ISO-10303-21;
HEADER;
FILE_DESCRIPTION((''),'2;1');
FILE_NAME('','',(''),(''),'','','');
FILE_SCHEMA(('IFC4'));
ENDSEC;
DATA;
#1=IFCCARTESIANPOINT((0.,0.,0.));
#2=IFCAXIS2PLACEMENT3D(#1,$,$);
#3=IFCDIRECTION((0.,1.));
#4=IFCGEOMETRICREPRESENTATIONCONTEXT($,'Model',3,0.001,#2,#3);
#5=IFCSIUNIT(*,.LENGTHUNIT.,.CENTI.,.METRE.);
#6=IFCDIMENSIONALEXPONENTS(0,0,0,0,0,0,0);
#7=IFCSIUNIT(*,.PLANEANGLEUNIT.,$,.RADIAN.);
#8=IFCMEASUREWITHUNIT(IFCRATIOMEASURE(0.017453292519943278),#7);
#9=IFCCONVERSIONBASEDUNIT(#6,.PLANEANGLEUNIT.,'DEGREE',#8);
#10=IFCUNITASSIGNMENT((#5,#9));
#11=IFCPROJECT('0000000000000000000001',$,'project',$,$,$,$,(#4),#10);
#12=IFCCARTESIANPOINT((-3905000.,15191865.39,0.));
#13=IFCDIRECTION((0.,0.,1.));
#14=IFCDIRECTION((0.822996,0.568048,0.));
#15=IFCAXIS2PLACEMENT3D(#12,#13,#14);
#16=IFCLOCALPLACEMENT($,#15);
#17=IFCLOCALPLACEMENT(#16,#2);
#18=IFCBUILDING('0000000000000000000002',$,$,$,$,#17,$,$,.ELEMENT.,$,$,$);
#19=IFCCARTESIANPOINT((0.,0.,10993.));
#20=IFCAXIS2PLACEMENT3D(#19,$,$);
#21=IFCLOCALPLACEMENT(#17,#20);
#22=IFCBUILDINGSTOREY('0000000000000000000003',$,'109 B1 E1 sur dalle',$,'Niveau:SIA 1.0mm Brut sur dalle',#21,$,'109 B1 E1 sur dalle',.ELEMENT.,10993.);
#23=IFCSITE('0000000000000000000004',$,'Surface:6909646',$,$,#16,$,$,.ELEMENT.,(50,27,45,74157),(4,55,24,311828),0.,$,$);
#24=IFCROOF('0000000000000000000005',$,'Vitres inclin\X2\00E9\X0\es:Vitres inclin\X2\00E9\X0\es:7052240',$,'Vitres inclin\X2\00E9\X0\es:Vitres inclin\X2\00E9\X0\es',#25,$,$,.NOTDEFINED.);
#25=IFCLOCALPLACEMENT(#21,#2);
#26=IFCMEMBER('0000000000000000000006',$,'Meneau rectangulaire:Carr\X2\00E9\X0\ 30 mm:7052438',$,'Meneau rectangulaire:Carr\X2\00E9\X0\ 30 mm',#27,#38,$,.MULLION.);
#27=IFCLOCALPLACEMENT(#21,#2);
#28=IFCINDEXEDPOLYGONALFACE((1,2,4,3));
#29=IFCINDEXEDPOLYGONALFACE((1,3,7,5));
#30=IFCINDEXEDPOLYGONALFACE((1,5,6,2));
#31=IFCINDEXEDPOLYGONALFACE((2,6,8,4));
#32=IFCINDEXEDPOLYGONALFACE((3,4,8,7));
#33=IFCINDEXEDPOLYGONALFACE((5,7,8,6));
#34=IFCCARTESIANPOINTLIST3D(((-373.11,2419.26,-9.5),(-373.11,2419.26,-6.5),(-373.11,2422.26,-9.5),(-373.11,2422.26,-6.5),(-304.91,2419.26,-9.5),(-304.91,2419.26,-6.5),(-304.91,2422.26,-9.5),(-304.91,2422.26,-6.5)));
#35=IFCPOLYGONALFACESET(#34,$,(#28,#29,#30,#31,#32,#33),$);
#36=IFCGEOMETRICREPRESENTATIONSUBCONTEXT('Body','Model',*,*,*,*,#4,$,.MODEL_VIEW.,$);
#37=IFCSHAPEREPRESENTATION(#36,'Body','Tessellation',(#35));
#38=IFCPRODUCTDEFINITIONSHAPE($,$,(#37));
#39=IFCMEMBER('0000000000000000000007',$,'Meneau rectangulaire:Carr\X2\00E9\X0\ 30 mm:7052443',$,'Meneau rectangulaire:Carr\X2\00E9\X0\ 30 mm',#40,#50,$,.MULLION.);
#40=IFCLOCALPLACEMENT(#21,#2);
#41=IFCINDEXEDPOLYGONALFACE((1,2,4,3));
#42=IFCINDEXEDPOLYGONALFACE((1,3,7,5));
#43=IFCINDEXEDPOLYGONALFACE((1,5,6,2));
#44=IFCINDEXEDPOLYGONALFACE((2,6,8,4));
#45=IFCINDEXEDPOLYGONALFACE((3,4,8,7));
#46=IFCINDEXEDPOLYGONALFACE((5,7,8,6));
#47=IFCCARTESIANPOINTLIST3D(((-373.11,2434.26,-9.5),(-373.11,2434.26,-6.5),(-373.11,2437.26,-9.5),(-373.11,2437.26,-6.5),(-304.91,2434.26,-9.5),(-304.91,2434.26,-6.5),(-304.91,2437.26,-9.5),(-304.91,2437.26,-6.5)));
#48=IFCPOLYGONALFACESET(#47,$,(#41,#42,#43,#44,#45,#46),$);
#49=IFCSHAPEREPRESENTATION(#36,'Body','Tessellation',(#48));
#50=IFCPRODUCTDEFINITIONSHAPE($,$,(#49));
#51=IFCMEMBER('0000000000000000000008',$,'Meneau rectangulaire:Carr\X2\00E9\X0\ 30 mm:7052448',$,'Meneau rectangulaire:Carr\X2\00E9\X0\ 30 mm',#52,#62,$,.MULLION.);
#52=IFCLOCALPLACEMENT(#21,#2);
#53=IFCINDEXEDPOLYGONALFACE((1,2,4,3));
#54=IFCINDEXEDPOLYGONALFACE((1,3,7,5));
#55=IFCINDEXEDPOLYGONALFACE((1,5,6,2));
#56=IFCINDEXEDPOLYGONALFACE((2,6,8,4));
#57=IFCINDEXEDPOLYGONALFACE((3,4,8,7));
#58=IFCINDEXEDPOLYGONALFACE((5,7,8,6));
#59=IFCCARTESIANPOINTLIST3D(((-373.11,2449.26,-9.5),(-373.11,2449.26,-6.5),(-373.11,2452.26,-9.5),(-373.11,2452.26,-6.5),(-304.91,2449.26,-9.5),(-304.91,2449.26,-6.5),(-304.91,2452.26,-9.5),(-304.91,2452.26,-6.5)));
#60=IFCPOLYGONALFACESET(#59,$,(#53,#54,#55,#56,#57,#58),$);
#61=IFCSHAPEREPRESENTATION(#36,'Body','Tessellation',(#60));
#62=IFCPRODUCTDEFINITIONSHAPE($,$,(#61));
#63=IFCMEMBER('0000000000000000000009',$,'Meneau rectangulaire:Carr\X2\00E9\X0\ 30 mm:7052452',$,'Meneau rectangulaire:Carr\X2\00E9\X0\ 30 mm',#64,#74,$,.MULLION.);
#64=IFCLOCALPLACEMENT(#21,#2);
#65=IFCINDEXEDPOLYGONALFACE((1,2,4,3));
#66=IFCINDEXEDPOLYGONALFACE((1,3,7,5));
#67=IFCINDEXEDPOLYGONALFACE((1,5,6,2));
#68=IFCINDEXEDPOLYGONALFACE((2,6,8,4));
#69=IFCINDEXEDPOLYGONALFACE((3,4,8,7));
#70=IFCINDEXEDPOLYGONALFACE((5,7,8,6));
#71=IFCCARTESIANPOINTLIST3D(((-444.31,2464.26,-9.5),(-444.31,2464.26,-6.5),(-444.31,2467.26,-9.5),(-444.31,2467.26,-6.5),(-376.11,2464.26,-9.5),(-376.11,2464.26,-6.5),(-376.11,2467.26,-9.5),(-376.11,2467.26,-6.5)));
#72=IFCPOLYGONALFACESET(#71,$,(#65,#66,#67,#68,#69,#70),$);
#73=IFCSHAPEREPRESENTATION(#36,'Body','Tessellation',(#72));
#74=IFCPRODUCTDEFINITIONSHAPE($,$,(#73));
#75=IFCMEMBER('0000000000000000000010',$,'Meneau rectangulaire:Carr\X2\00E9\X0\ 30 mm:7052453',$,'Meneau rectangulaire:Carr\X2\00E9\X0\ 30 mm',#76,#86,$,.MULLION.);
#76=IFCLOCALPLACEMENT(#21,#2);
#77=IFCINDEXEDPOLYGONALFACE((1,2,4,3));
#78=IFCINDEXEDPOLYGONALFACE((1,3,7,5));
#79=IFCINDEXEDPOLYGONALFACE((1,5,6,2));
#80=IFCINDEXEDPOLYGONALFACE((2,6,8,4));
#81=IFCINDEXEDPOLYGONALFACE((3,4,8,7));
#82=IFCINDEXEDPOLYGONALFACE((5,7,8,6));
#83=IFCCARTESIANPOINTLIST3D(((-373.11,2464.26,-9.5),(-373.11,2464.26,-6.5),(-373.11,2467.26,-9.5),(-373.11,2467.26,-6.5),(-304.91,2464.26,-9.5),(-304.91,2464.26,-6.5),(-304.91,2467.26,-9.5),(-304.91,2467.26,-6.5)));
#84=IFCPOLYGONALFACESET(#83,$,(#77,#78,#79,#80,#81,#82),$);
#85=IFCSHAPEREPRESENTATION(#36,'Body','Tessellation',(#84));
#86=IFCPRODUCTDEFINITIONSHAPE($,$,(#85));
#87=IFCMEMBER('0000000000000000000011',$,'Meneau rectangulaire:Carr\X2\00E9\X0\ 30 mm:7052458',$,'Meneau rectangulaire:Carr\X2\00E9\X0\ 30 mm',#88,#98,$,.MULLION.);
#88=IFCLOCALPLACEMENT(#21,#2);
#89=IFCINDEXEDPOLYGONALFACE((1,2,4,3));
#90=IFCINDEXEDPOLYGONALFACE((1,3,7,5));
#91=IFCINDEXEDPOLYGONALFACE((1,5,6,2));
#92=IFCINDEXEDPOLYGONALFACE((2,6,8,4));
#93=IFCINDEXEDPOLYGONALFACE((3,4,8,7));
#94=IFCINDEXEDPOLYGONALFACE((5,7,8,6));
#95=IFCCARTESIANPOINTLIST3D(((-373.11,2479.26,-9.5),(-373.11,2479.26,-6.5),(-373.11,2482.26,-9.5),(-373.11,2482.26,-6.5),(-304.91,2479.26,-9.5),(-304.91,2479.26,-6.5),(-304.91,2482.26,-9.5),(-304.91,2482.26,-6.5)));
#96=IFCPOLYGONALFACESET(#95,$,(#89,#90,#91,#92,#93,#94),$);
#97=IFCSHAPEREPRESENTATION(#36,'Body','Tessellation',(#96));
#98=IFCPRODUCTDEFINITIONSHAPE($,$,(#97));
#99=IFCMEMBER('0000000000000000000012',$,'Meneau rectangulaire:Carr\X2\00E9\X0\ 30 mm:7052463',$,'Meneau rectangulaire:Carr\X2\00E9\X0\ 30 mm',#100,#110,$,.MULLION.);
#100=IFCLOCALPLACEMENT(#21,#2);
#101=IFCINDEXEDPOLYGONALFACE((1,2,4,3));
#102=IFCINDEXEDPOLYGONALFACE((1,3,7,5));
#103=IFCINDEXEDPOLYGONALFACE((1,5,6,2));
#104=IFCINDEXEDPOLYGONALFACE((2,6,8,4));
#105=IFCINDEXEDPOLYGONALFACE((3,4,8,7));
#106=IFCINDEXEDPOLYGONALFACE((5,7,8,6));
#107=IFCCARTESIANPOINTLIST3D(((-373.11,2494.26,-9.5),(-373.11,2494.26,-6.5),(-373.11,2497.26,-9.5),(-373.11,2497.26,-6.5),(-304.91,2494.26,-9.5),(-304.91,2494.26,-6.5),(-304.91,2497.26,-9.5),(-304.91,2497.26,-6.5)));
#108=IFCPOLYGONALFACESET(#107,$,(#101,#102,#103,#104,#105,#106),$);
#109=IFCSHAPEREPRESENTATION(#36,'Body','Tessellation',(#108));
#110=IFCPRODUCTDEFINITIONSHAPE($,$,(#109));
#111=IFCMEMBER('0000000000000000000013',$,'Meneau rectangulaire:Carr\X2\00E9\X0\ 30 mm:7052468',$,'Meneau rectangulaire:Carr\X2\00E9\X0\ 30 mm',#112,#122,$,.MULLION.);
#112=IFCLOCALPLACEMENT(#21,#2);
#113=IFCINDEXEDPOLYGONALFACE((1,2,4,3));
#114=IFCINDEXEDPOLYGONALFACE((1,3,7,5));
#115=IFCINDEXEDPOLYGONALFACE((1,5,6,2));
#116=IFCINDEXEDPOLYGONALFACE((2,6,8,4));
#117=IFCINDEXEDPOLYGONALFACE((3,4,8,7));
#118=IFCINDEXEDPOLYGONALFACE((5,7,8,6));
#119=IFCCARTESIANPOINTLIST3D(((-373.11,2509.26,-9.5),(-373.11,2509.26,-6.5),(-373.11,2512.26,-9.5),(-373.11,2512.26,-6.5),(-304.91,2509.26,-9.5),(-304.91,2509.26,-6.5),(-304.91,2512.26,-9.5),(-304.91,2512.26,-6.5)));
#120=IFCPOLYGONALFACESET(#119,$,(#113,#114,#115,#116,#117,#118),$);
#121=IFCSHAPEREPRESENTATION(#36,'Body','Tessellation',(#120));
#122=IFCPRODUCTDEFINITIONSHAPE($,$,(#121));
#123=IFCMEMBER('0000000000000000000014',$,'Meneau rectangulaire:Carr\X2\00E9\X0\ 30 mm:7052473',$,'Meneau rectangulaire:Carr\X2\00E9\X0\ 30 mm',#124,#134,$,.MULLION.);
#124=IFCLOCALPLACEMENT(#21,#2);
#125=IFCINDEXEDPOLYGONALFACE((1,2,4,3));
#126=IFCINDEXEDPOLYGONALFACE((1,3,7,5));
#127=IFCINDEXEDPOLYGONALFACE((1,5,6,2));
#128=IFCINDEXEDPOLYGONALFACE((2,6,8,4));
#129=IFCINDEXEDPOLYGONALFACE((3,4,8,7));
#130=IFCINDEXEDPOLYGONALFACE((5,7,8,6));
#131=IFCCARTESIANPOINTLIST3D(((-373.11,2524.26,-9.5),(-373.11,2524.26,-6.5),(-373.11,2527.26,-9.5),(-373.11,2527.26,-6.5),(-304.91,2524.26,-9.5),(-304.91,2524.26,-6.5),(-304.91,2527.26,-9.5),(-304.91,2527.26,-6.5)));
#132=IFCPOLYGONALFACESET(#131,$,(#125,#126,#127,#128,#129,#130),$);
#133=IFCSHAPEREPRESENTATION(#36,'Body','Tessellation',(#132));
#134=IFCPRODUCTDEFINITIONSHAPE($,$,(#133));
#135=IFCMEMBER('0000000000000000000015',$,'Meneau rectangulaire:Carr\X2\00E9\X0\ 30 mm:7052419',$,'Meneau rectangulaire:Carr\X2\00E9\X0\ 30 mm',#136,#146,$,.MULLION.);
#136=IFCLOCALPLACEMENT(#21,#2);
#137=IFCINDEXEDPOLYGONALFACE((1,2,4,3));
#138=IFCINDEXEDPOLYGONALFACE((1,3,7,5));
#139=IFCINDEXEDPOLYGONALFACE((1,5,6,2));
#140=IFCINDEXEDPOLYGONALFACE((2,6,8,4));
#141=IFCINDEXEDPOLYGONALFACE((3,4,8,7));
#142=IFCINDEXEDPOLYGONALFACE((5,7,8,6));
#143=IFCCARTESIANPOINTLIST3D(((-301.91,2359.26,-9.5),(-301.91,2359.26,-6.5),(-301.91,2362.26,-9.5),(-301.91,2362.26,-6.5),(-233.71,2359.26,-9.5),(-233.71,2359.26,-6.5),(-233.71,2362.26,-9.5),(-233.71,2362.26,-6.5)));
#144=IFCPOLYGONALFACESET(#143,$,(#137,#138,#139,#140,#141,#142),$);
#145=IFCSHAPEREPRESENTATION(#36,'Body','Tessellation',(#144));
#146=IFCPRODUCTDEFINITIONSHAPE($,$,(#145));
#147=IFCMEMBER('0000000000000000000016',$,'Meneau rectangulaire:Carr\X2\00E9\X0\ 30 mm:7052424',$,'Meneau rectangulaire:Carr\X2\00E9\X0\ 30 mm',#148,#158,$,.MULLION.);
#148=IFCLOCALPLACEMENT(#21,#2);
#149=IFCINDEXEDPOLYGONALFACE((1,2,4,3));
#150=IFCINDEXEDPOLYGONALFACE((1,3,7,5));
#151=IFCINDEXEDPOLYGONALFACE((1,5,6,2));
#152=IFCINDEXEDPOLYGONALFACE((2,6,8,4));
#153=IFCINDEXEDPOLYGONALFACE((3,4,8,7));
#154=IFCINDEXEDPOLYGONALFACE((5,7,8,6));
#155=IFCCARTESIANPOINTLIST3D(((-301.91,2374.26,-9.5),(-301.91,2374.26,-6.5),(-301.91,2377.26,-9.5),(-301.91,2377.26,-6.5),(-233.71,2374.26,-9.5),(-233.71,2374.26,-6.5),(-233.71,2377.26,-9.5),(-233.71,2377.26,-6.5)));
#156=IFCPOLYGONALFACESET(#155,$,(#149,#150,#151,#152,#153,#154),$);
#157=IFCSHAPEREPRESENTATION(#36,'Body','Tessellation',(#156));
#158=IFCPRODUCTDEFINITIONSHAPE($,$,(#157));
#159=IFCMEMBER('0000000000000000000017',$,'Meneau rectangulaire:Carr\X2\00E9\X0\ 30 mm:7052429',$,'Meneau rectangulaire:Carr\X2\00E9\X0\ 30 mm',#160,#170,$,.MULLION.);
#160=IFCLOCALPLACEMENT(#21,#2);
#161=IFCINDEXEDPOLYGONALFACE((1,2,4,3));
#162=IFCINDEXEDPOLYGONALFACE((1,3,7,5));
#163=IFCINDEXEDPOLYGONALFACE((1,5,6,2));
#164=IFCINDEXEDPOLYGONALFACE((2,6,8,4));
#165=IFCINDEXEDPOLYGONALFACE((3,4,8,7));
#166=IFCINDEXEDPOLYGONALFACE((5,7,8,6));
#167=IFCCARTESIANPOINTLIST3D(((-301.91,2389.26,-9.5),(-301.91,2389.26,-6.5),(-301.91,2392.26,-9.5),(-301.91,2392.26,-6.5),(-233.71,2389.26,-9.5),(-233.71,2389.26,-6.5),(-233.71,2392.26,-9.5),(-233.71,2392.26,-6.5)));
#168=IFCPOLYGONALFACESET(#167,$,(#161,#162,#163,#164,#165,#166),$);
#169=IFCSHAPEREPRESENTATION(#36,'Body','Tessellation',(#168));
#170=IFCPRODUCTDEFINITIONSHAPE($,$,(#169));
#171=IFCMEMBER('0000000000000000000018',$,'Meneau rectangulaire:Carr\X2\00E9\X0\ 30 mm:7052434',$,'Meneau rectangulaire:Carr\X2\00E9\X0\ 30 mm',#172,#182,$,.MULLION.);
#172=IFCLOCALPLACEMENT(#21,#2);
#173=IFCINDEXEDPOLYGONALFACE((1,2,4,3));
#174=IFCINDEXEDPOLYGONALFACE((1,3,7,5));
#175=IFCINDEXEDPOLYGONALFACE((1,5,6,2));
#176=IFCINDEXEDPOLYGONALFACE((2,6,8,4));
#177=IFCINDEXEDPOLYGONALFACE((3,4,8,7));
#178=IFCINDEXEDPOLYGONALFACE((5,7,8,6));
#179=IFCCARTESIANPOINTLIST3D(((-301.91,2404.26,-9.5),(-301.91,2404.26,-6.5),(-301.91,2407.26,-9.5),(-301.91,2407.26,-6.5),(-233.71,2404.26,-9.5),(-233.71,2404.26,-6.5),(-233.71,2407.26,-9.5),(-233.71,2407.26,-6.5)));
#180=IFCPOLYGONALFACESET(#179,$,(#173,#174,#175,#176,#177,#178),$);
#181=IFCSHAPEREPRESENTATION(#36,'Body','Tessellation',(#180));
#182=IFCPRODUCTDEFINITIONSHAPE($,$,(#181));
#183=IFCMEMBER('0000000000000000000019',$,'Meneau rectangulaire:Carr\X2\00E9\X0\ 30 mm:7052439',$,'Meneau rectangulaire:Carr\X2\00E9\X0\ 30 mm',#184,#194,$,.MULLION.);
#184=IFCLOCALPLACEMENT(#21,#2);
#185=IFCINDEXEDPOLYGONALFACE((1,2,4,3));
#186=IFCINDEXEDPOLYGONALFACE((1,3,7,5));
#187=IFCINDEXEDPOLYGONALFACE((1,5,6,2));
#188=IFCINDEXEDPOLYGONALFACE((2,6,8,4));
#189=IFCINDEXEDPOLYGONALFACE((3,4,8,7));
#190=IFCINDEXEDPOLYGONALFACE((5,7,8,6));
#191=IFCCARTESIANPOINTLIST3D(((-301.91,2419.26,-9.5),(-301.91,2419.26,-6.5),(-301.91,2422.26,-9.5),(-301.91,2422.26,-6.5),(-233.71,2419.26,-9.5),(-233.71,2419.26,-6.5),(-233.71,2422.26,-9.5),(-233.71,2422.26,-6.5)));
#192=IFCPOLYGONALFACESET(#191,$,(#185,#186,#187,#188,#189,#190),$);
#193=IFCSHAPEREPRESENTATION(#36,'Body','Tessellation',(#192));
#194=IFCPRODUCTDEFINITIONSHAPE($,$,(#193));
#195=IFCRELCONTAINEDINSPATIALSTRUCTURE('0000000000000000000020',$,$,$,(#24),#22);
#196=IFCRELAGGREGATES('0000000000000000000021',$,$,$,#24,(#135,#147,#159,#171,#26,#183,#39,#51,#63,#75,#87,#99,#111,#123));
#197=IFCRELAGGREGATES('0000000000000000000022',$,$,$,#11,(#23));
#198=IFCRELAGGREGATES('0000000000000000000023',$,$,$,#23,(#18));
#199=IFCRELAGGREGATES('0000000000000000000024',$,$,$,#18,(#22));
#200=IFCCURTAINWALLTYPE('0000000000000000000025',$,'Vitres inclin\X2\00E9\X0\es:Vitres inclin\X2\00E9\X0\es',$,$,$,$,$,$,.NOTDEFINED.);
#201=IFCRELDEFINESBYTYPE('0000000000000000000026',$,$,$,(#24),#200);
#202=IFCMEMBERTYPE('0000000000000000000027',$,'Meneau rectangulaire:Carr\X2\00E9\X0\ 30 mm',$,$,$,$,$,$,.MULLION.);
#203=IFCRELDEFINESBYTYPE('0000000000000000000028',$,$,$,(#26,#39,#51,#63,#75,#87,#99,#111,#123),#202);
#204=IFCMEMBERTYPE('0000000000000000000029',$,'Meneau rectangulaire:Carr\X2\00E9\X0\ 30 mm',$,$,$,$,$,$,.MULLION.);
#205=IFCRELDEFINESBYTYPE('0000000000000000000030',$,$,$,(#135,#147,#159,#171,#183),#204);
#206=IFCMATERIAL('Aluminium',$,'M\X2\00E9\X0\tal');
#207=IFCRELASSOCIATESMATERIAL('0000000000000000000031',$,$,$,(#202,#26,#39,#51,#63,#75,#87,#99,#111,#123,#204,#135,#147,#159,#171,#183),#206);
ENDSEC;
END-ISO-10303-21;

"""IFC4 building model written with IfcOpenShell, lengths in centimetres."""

from ifc_helpers import new_model, entity, si_unit, converted_unit, direction, frame, origin, place, context, subcontext, project, spatial, indexed_curve, outline, extrude, source, transform, mapped, material, type_object, type_shapes, element, aggregate, save


model = new_model("IFC4")

# Units and contexts
model_context = context("Model", 3, precision=0.001, world=origin(), true_north=direction((0.0, 1.0)))
body_context = subcontext(model_context, "Body", "Model", "MODEL_VIEW")
ifc_project = project(units=[si_unit("LENGTHUNIT", "METRE", prefix="CENTI"), converted_unit("PLANEANGLEUNIT", "DEGREE", entity("IfcRatioMeasure", 0.017453292519943278), si_unit("PLANEANGLEUNIT", "RADIAN"), dimensions=[0, 0, 0, 0, 0, 0, 0])], contexts=[model_context])

# Site, building, storey
site_placement = place(None, frame((-3905000.0, 15191865.39, 0.0), z_axis=(0.0, 0.0, 1.0), x_axis=(0.822996, 0.568048, 0.0)))
site = spatial("IfcSite", under=ifc_project, at=site_placement, Name="Surface:6909646", CompositionType="ELEMENT", RefLatitude=(50, 27, 45, 74157), RefLongitude=(4, 55, 24, 311828), RefElevation=0.0)
building_placement = place(site_placement, origin())
building = spatial("IfcBuilding", under=site, at=building_placement, CompositionType="ELEMENT")
storey_placement = place(building_placement, frame((0.0, 0.0, 10993.0)))
storey = spatial("IfcBuildingStorey", under=building, at=storey_placement, Name="109 B1 E1 sur dalle", ObjectType="Niveau:SIA 1.0mm Brut sur dalle", LongName="109 B1 E1 sur dalle", CompositionType="ELEMENT", Elevation=10993.0)

# Roof, members
curtain_wall_type = type_object("IfcCurtainWallType", Name="Vitres inclinées:Vitres inclinées", PredefinedType="NOTDEFINED")
roof_placement = place(storey_placement, frame((0.0, 0.0, -10993.0)))
roof = element("IfcRoof", 1, at=roof_placement, inside=storey, type_object=curtain_wall_type, Name="Vitres inclinées:Vitres inclinées:7052240", ObjectType="Vitres inclinées:Vitres inclinées", PredefinedType="NOTDEFINED")
ifc_material = material(Name="Aluminium", Category="Métal")
member_type_1 = type_object("IfcMemberType", Name="Meneau rectangulaire:Carré 30 mm", PredefinedType="MULLION", material=ifc_material)
shared_shape_1 = source(origin(), body_context, "Body", "SweptSolid", [
    extrude(outline(indexed_curve([(-1.5, -1.5), (1.5, -1.5), (1.5, 1.5), (-1.5, 1.5), (-1.5, -1.5)], self_intersect=False)), frame((0.0, 0.0, -68.2), z_axis=(0.0, 0.0, 1.0), x_axis=(0.0, -1.0, 0.0)), (0.0, 0.0, 1.0), 68.2),
])
type_shapes(member_type_1, [shared_shape_1])
member_1_placement = place(roof_placement, frame((-373.11, 2420.76, 10985.0), z_axis=(-1.0, 0.0, 0.0), x_axis=(0.0, 1.0, 0.0)))
member_1 = element("IfcMember", 2, at=member_1_placement, type_object=member_type_1, material=ifc_material, Name="Meneau rectangulaire:Carré 30 mm:7052438", ObjectType="Meneau rectangulaire:Carré 30 mm", PredefinedType="MULLION", context=body_context, shape_type="MappedRepresentation", body=[
    mapped(shared_shape_1, transform((0.0, 0.0, 0.0), scale=1.0)),
])
member_2_placement = place(roof_placement, frame((-373.11, 2435.76, 10985.0), z_axis=(-1.0, 0.0, 0.0), x_axis=(0.0, 1.0, 0.0)))
member_2 = element("IfcMember", 3, at=member_2_placement, type_object=member_type_1, material=ifc_material, Name="Meneau rectangulaire:Carré 30 mm:7052443", ObjectType="Meneau rectangulaire:Carré 30 mm", PredefinedType="MULLION", context=body_context, shape_type="MappedRepresentation", body=[
    mapped(shared_shape_1, transform((0.0, 0.0, 0.0), scale=1.0)),
])
member_3_placement = place(roof_placement, frame((-373.11, 2450.76, 10985.0), z_axis=(-1.0, 0.0, 0.0), x_axis=(0.0, 1.0, 0.0)))
member_3 = element("IfcMember", 4, at=member_3_placement, type_object=member_type_1, material=ifc_material, Name="Meneau rectangulaire:Carré 30 mm:7052448", ObjectType="Meneau rectangulaire:Carré 30 mm", PredefinedType="MULLION", context=body_context, shape_type="MappedRepresentation", body=[
    mapped(shared_shape_1, transform((0.0, 0.0, 0.0), scale=1.0)),
])
member_4_placement = place(roof_placement, frame((-444.31, 2465.76, 10985.0), z_axis=(-1.0, 0.0, 0.0), x_axis=(0.0, 1.0, 0.0)))
member_4 = element("IfcMember", 5, at=member_4_placement, type_object=member_type_1, material=ifc_material, Name="Meneau rectangulaire:Carré 30 mm:7052452", ObjectType="Meneau rectangulaire:Carré 30 mm", PredefinedType="MULLION", context=body_context, shape_type="MappedRepresentation", body=[
    mapped(shared_shape_1, transform((0.0, 0.0, 0.0), scale=1.0)),
])
member_5_placement = place(roof_placement, frame((-373.11, 2465.76, 10985.0), z_axis=(-1.0, 0.0, 0.0), x_axis=(0.0, 1.0, 0.0)))
member_5 = element("IfcMember", 6, at=member_5_placement, type_object=member_type_1, material=ifc_material, Name="Meneau rectangulaire:Carré 30 mm:7052453", ObjectType="Meneau rectangulaire:Carré 30 mm", PredefinedType="MULLION", context=body_context, shape_type="MappedRepresentation", body=[
    mapped(shared_shape_1, transform((0.0, 0.0, 0.0), scale=1.0)),
])
member_6_placement = place(roof_placement, frame((-373.11, 2480.76, 10985.0), z_axis=(-1.0, 0.0, 0.0), x_axis=(0.0, 1.0, 0.0)))
member_6 = element("IfcMember", 7, at=member_6_placement, type_object=member_type_1, material=ifc_material, Name="Meneau rectangulaire:Carré 30 mm:7052458", ObjectType="Meneau rectangulaire:Carré 30 mm", PredefinedType="MULLION", context=body_context, shape_type="MappedRepresentation", body=[
    mapped(shared_shape_1, transform((0.0, 0.0, 0.0), scale=1.0)),
])
member_7_placement = place(roof_placement, frame((-373.11, 2495.76, 10985.0), z_axis=(-1.0, 0.0, 0.0), x_axis=(0.0, 1.0, 0.0)))
member_7 = element("IfcMember", 8, at=member_7_placement, type_object=member_type_1, material=ifc_material, Name="Meneau rectangulaire:Carré 30 mm:7052463", ObjectType="Meneau rectangulaire:Carré 30 mm", PredefinedType="MULLION", context=body_context, shape_type="MappedRepresentation", body=[
    mapped(shared_shape_1, transform((0.0, 0.0, 0.0), scale=1.0)),
])
member_8_placement = place(roof_placement, frame((-373.11, 2510.76, 10985.0), z_axis=(-1.0, 0.0, 0.0), x_axis=(0.0, 1.0, 0.0)))
member_8 = element("IfcMember", 9, at=member_8_placement, type_object=member_type_1, material=ifc_material, Name="Meneau rectangulaire:Carré 30 mm:7052468", ObjectType="Meneau rectangulaire:Carré 30 mm", PredefinedType="MULLION", context=body_context, shape_type="MappedRepresentation", body=[
    mapped(shared_shape_1, transform((0.0, 0.0, 0.0), scale=1.0)),
])
member_9_placement = place(roof_placement, frame((-373.11, 2525.76, 10985.0), z_axis=(-1.0, 0.0, 0.0), x_axis=(0.0, 1.0, 0.0)))
member_9 = element("IfcMember", 10, at=member_9_placement, type_object=member_type_1, material=ifc_material, Name="Meneau rectangulaire:Carré 30 mm:7052473", ObjectType="Meneau rectangulaire:Carré 30 mm", PredefinedType="MULLION", context=body_context, shape_type="MappedRepresentation", body=[
    mapped(shared_shape_1, transform((0.0, 0.0, 0.0), scale=1.0)),
])
member_type_2 = type_object("IfcMemberType", Name="Meneau rectangulaire:Carré 30 mm", PredefinedType="MULLION", material=ifc_material)
shared_shape_2 = source(origin(), body_context, "Body", "SweptSolid", [
    extrude(outline(indexed_curve([(-1.5, -1.5), (1.5, -1.5), (1.5, 1.5), (-1.5, 1.5), (-1.5, -1.5)], self_intersect=False)), frame((0.0, 0.0, -68.2), z_axis=(0.0, 0.0, 1.0), x_axis=(0.0, -1.0, 0.0)), (0.0, 0.0, 1.0), 68.2),
])
type_shapes(member_type_2, [shared_shape_2])
member_10_placement = place(roof_placement, frame((-301.91, 2360.76, 10985.0), z_axis=(-1.0, 0.0, 0.0), x_axis=(0.0, 1.0, 0.0)))
member_10 = element("IfcMember", 11, at=member_10_placement, type_object=member_type_2, material=ifc_material, Name="Meneau rectangulaire:Carré 30 mm:7052419", ObjectType="Meneau rectangulaire:Carré 30 mm", PredefinedType="MULLION", context=body_context, shape_type="MappedRepresentation", body=[
    mapped(shared_shape_2, transform((0.0, 0.0, 0.0), scale=1.0)),
])
member_11_placement = place(roof_placement, frame((-301.91, 2375.76, 10985.0), z_axis=(-1.0, 0.0, 0.0), x_axis=(0.0, 1.0, 0.0)))
member_11 = element("IfcMember", 12, at=member_11_placement, type_object=member_type_2, material=ifc_material, Name="Meneau rectangulaire:Carré 30 mm:7052424", ObjectType="Meneau rectangulaire:Carré 30 mm", PredefinedType="MULLION", context=body_context, shape_type="MappedRepresentation", body=[
    mapped(shared_shape_2, transform((0.0, 0.0, 0.0), scale=1.0)),
])
member_12_placement = place(roof_placement, frame((-301.91, 2390.76, 10985.0), z_axis=(-1.0, 0.0, 0.0), x_axis=(0.0, 1.0, 0.0)))
member_12 = element("IfcMember", 13, at=member_12_placement, type_object=member_type_2, material=ifc_material, Name="Meneau rectangulaire:Carré 30 mm:7052429", ObjectType="Meneau rectangulaire:Carré 30 mm", PredefinedType="MULLION", context=body_context, shape_type="MappedRepresentation", body=[
    mapped(shared_shape_2, transform((0.0, 0.0, 0.0), scale=1.0)),
])
member_13_placement = place(roof_placement, frame((-301.91, 2405.76, 10985.0), z_axis=(-1.0, 0.0, 0.0), x_axis=(0.0, 1.0, 0.0)))
member_13 = element("IfcMember", 14, at=member_13_placement, type_object=member_type_2, material=ifc_material, Name="Meneau rectangulaire:Carré 30 mm:7052434", ObjectType="Meneau rectangulaire:Carré 30 mm", PredefinedType="MULLION", context=body_context, shape_type="MappedRepresentation", body=[
    mapped(shared_shape_2, transform((0.0, 0.0, 0.0), scale=1.0)),
])
member_14_placement = place(roof_placement, frame((-301.91, 2420.76, 10985.0), z_axis=(-1.0, 0.0, 0.0), x_axis=(0.0, 1.0, 0.0)))
member_14 = element("IfcMember", 15, at=member_14_placement, type_object=member_type_2, material=ifc_material, Name="Meneau rectangulaire:Carré 30 mm:7052439", ObjectType="Meneau rectangulaire:Carré 30 mm", PredefinedType="MULLION", context=body_context, shape_type="MappedRepresentation", body=[
    mapped(shared_shape_2, transform((0.0, 0.0, 0.0), scale=1.0)),
])
aggregate(roof, [member_10, member_11, member_12, member_13, member_1, member_14, member_2, member_3, member_4, member_5, member_6, member_7, member_8, member_9])

save(model, "model.ifc")
